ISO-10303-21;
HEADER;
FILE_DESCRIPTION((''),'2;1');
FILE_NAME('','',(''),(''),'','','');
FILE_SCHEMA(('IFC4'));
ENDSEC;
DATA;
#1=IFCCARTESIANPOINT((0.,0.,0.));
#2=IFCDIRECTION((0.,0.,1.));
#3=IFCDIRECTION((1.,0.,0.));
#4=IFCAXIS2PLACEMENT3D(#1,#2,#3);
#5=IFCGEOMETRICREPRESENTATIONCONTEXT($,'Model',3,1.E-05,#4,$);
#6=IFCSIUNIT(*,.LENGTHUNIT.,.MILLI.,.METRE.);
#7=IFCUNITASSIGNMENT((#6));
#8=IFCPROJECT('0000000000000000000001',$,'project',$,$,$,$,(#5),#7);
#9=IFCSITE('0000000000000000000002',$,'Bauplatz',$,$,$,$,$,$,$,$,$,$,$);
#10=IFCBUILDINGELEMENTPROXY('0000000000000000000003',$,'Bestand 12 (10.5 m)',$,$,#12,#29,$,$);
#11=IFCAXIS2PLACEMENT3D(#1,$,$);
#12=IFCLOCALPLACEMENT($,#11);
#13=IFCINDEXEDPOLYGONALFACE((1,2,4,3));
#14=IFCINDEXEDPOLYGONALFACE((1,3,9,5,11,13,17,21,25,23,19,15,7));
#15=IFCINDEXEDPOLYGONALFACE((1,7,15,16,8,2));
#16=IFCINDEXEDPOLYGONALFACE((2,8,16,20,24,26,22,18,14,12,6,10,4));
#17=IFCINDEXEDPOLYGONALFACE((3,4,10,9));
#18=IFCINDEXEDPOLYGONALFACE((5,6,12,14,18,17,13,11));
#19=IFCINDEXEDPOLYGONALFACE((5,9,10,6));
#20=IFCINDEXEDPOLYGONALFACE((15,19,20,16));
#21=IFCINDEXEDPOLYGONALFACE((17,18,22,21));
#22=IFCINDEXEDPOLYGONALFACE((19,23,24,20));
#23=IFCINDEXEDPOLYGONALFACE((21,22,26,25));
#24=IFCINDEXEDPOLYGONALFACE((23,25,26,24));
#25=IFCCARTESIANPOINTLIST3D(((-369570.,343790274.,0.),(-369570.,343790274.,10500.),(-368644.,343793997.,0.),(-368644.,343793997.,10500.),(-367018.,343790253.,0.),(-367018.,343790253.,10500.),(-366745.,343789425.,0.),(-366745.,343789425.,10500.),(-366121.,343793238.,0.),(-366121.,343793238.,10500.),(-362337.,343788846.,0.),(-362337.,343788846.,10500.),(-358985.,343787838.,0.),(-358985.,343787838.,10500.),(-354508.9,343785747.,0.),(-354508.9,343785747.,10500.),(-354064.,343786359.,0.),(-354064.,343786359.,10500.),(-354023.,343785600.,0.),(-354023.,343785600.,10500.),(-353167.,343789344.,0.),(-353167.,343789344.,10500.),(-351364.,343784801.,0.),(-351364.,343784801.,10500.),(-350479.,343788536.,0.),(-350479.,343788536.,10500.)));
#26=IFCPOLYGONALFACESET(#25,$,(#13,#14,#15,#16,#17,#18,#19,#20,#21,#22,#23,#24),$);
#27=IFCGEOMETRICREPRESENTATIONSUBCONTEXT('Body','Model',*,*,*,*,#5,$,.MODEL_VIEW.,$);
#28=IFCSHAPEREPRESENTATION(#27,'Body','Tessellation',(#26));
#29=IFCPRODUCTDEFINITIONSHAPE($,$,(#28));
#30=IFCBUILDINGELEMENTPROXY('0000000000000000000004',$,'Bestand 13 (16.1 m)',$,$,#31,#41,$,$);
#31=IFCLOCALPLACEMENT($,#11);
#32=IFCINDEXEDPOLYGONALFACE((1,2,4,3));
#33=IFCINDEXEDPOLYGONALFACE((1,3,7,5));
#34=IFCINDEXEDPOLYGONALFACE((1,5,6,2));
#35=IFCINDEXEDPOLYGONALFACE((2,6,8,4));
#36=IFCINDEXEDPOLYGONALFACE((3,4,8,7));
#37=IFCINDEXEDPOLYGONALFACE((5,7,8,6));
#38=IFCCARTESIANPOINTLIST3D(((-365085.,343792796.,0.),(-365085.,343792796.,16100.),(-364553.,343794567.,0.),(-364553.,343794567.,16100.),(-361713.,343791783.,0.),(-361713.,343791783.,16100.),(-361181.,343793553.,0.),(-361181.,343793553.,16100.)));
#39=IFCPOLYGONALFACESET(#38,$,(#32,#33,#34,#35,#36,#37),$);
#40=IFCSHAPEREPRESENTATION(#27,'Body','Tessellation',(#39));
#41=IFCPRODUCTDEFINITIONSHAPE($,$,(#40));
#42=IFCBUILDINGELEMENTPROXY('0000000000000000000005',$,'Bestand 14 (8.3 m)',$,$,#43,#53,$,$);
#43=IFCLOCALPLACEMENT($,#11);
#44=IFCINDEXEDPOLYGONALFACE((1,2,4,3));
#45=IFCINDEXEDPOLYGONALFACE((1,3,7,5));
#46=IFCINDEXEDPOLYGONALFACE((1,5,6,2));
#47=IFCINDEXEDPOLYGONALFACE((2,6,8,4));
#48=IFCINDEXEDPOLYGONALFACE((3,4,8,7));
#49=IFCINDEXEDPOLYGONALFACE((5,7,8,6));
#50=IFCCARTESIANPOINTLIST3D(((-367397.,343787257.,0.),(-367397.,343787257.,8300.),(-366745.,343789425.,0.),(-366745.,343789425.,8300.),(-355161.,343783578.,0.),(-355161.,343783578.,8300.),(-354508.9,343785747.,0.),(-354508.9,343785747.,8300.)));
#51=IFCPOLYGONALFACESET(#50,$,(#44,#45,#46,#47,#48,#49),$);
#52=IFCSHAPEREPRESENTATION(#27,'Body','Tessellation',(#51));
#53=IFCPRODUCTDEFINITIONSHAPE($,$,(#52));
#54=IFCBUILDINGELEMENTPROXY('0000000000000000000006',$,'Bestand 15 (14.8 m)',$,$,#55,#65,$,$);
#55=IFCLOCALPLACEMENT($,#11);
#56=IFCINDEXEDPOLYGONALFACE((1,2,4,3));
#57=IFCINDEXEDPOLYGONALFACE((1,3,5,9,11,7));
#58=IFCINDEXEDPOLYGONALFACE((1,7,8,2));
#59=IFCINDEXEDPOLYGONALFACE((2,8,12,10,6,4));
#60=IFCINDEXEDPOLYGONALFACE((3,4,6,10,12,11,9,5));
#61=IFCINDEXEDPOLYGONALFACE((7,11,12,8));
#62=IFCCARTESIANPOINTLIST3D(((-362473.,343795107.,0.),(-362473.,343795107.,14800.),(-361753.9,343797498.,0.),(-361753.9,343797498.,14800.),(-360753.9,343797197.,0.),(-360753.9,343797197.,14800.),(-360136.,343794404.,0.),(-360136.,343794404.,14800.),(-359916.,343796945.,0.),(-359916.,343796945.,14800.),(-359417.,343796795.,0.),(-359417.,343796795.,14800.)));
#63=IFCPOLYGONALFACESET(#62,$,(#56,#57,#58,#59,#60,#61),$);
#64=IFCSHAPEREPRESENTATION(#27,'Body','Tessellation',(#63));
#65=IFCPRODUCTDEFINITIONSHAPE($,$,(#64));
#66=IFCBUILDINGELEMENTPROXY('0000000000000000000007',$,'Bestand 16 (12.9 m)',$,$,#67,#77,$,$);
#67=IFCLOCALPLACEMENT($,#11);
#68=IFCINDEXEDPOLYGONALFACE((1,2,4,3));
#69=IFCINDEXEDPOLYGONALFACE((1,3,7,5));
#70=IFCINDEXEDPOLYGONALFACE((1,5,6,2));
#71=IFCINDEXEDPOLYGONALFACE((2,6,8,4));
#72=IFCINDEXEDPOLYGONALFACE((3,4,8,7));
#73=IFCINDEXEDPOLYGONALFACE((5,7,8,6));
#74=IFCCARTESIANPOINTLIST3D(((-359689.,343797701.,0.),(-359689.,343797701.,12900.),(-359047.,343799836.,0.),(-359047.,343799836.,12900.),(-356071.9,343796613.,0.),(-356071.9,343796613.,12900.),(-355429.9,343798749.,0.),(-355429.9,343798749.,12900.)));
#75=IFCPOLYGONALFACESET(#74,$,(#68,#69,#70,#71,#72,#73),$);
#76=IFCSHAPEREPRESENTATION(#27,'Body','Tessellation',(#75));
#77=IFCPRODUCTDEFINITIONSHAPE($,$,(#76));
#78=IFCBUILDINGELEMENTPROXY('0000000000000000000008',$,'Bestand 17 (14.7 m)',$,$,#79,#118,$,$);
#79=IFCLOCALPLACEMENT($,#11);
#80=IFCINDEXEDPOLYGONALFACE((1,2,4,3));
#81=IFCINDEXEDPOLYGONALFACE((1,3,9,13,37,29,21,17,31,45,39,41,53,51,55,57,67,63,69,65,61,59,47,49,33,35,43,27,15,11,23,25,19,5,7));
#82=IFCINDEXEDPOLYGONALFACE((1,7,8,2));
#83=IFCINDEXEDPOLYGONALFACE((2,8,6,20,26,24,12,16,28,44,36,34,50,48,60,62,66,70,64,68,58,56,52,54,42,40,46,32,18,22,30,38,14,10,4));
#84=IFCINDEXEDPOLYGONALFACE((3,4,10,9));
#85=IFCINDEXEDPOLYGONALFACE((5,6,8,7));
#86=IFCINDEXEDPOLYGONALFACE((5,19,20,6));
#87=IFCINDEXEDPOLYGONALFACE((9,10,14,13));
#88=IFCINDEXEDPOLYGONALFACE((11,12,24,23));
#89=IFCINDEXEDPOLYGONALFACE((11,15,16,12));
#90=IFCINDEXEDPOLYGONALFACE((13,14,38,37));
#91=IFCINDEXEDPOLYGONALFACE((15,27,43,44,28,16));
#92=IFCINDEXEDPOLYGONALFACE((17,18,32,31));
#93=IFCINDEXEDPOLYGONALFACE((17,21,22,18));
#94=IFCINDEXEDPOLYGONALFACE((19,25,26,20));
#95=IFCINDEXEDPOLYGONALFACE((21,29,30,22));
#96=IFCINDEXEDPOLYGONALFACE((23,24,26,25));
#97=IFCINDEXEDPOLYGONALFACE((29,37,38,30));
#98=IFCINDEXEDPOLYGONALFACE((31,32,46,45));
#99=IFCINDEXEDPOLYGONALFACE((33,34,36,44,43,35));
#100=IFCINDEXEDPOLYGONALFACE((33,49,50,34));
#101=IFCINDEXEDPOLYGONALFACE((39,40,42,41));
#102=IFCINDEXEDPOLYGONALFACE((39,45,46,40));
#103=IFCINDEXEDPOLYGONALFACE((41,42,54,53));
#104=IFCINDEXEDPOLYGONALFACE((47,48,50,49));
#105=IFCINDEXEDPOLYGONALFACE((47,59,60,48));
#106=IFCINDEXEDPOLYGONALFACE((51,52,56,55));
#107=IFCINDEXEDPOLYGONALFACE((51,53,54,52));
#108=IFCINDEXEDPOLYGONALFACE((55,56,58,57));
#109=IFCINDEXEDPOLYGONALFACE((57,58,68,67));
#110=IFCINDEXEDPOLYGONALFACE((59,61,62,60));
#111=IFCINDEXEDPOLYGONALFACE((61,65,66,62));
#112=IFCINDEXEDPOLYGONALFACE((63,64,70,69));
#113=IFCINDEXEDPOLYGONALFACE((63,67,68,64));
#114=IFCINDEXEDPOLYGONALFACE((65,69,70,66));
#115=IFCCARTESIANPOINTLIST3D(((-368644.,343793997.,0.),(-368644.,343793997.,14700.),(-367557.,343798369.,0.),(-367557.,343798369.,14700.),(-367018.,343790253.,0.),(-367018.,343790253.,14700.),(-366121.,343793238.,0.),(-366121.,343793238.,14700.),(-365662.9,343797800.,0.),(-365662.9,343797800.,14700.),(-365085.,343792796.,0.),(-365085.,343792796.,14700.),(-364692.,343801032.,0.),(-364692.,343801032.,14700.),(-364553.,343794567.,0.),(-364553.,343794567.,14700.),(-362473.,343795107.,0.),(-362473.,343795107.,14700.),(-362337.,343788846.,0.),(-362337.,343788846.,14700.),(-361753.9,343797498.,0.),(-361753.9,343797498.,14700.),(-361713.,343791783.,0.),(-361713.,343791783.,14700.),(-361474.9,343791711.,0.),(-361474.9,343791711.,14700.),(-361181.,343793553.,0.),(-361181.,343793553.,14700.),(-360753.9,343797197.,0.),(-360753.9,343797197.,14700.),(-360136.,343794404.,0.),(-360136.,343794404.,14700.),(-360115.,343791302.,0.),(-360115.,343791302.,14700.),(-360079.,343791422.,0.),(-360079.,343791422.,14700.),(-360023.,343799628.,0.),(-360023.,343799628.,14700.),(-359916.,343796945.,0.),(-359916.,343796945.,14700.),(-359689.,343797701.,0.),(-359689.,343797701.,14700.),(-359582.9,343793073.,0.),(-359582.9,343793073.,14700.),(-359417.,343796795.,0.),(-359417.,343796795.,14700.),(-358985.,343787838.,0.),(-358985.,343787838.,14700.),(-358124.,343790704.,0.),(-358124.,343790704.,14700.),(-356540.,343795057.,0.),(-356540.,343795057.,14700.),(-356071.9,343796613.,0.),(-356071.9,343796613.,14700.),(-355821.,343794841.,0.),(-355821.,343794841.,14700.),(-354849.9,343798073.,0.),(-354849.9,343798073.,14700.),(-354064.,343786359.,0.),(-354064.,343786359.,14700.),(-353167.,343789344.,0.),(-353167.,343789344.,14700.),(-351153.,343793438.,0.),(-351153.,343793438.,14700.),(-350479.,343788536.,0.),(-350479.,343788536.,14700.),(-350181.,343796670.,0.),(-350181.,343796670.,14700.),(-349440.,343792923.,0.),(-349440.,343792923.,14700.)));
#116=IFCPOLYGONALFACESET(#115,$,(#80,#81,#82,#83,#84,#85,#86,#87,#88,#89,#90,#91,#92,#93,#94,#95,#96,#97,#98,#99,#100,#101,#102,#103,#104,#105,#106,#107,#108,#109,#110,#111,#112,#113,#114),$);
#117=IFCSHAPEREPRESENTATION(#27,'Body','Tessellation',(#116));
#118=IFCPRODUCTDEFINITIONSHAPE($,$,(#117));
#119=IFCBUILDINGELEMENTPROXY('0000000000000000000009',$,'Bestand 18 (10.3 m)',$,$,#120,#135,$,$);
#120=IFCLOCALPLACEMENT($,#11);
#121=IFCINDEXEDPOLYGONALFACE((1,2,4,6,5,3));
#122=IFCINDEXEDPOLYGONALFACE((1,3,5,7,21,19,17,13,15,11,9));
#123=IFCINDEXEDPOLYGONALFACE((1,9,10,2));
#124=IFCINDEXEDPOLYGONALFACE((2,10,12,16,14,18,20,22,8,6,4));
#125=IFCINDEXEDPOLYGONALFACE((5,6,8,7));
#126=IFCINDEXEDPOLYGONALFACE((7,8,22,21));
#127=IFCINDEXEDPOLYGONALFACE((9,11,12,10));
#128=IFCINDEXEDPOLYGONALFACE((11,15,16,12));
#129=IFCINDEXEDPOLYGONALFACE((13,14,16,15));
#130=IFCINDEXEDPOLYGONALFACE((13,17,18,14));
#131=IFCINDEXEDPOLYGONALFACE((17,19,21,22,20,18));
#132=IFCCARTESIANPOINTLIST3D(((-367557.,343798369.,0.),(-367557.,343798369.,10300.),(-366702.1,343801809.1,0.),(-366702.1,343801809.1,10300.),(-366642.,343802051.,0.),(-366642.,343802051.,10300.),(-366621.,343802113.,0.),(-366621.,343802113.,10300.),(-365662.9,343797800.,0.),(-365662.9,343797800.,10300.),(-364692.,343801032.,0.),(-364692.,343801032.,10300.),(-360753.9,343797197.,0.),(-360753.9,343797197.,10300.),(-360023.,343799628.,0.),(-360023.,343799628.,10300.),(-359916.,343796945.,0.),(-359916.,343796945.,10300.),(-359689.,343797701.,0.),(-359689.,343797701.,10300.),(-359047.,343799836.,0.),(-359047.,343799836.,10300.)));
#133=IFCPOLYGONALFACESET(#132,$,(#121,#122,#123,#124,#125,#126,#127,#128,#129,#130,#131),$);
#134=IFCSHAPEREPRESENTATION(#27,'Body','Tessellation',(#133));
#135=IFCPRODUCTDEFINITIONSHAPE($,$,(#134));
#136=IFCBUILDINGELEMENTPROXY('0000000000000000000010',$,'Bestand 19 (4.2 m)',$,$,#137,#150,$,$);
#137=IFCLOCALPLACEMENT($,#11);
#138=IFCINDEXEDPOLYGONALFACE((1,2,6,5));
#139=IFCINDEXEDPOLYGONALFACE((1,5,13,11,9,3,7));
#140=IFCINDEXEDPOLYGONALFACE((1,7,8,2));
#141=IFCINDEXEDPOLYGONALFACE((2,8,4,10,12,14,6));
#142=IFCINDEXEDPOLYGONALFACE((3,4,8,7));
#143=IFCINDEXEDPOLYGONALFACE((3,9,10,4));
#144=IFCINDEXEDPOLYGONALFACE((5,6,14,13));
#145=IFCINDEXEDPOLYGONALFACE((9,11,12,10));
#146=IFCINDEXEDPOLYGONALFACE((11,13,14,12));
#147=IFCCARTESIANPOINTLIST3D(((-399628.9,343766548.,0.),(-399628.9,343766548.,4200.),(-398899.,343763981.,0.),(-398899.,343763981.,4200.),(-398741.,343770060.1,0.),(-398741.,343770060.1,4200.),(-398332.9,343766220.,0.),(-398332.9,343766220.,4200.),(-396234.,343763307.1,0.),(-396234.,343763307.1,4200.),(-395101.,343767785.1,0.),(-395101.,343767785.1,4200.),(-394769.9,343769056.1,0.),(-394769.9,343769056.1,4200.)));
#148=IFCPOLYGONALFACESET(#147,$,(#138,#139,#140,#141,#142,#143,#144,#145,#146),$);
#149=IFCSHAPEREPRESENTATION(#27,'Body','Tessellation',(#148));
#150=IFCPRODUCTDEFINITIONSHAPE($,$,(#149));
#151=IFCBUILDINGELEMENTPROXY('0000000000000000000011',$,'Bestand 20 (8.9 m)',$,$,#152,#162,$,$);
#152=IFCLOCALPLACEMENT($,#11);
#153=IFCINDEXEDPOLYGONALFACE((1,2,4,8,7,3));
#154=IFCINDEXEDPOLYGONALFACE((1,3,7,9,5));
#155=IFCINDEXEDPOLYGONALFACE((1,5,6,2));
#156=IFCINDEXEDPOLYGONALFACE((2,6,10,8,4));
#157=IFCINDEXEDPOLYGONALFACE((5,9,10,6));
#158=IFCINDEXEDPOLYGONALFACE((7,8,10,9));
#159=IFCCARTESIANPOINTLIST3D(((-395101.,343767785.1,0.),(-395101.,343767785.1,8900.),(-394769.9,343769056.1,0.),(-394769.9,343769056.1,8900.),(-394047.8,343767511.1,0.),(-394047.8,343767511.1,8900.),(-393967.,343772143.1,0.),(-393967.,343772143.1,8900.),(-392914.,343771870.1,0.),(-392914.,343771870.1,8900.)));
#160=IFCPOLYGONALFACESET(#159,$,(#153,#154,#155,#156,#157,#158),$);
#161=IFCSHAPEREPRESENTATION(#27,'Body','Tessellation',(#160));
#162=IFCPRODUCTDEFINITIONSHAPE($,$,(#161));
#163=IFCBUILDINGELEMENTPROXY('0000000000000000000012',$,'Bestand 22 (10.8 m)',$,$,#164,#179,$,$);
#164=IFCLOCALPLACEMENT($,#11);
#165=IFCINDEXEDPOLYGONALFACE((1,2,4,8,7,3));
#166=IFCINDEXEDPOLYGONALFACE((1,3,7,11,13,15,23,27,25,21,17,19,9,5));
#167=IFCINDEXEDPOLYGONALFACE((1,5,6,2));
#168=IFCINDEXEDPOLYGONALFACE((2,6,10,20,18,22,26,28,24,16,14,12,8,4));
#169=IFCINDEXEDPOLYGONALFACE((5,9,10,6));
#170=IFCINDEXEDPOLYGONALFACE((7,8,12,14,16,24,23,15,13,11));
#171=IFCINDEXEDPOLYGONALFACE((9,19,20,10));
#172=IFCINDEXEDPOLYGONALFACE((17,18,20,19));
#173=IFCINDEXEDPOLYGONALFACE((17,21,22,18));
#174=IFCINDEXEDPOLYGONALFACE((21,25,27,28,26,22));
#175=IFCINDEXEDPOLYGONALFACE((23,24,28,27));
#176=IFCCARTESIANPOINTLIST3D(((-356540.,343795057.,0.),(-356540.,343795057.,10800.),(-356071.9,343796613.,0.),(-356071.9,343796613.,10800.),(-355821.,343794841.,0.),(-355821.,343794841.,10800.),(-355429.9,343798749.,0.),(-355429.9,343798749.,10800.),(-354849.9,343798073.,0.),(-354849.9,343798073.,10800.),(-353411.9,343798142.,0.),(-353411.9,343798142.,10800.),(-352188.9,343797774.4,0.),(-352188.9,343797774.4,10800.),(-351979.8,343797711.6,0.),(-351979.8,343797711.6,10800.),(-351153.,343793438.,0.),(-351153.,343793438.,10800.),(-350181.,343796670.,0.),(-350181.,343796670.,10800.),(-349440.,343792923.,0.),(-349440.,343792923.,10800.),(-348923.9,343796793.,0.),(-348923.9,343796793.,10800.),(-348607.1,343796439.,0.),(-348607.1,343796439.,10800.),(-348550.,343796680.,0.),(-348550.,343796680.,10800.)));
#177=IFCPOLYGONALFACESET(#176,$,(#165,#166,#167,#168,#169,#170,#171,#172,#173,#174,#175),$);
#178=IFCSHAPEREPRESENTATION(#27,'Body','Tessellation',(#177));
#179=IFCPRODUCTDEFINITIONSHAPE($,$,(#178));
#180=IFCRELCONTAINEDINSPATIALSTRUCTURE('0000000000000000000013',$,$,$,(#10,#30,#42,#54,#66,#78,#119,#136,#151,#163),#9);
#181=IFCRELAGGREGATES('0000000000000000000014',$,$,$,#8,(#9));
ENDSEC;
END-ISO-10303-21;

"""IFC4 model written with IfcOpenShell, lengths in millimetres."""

from ifc_helpers import new_model, si_unit, origin_with_axes, place, context, subcontext, project, spatial, indexed_curve, outline, extrude, element, save


model = new_model("IFC4")

# Units and contexts
model_context = context("Model", 3, precision=1e-05, world=origin_with_axes())
body_context = subcontext(model_context, "Body", "Model", "MODEL_VIEW")
ifc_project = project(units=[si_unit("LENGTHUNIT", "METRE", prefix="MILLI")], contexts=[model_context])

# Site
site = spatial("IfcSite", under=ifc_project, Name="Bauplatz")

# Building element proxies
proxy_1_placement = place(None, origin_with_axes())
element("IfcBuildingElementProxy", 1, at=proxy_1_placement, inside=site, Name="Bestand 12 (10.5 m)", context=body_context, shape_type="SweptSolid", body=[
    extrude(outline(indexed_curve([(-366121.0, 343793238.0), (-368644.0, 343793997.0), (-369570.0, 343790274.0), (-366745.0, 343789425.0), (-354508.9, 343785747.0), (-354023.0, 343785600.0), (-351364.0, 343784801.0), (-350479.0, 343788536.0), (-353167.0, 343789344.0), (-354064.0, 343786359.0), (-358985.0, 343787838.0), (-362337.0, 343788846.0), (-367018.0, 343790253.0)])), None, (0.0, 0.0, 1.0), 10500.0),
])
proxy_2_placement = place(None, origin_with_axes())
element("IfcBuildingElementProxy", 2, at=proxy_2_placement, inside=site, Name="Bestand 13 (16.1 m)", context=body_context, shape_type="SweptSolid", body=[
    extrude(outline(indexed_curve([(-361181.0, 343793553.0), (-364553.0, 343794567.0), (-365085.0, 343792796.0), (-361713.0, 343791783.0)])), None, (0.0, 0.0, 1.0), 16100.0),
])
proxy_3_placement = place(None, origin_with_axes())
element("IfcBuildingElementProxy", 3, at=proxy_3_placement, inside=site, Name="Bestand 14 (8.3 m)", context=body_context, shape_type="SweptSolid", body=[
    extrude(outline(indexed_curve([(-354508.9, 343785747.0), (-366745.0, 343789425.0), (-367397.0, 343787257.0), (-355161.0, 343783578.0)])), None, (0.0, 0.0, 1.0), 8300.0),
])
proxy_4_placement = place(None, origin_with_axes())
element("IfcBuildingElementProxy", 4, at=proxy_4_placement, inside=site, Name="Bestand 15 (14.8 m)", context=body_context, shape_type="SweptSolid", body=[
    extrude(outline(indexed_curve([(-360753.9, 343797197.0), (-361753.9, 343797498.0), (-362473.0, 343795107.0), (-360136.0, 343794404.0), (-359417.0, 343796795.0), (-359916.0, 343796945.0)])), None, (0.0, 0.0, 1.0), 14800.0),
])
proxy_5_placement = place(None, origin_with_axes())
element("IfcBuildingElementProxy", 5, at=proxy_5_placement, inside=site, Name="Bestand 16 (12.9 m)", context=body_context, shape_type="SweptSolid", body=[
    extrude(outline(indexed_curve([(-355429.9, 343798749.0), (-359047.0, 343799836.0), (-359689.0, 343797701.0), (-356071.9, 343796613.0)])), None, (0.0, 0.0, 1.0), 12900.0),
])
proxy_6_placement = place(None, origin_with_axes())
element("IfcBuildingElementProxy", 6, at=proxy_6_placement, inside=site, Name="Bestand 17 (14.7 m)", context=body_context, shape_type="SweptSolid", body=[
    extrude(outline(indexed_curve([(-360023.0, 343799628.0), (-364692.0, 343801032.0), (-365662.9, 343797800.0), (-367557.0, 343798369.0), (-368644.0, 343793997.0), (-366121.0, 343793238.0), (-367018.0, 343790253.0), (-362337.0, 343788846.0), (-361474.9, 343791711.0), (-361713.0, 343791783.0), (-365085.0, 343792796.0), (-364553.0, 343794567.0), (-361181.0, 343793553.0), (-359582.9, 343793073.0), (-360079.0, 343791422.0), (-360115.0, 343791302.0), (-358124.0, 343790704.0), (-358985.0, 343787838.0), (-354064.0, 343786359.0), (-353167.0, 343789344.0), (-350479.0, 343788536.0), (-349440.0, 343792923.0), (-351153.0, 343793438.0), (-350181.0, 343796670.0), (-354849.9, 343798073.0), (-355821.0, 343794841.0), (-356540.0, 343795057.0), (-356071.9, 343796613.0), (-359689.0, 343797701.0), (-359916.0, 343796945.0), (-359417.0, 343796795.0), (-360136.0, 343794404.0), (-362473.0, 343795107.0), (-361753.9, 343797498.0), (-360753.9, 343797197.0)])), None, (0.0, 0.0, 1.0), 14700.0),
])
proxy_7_placement = place(None, origin_with_axes())
element("IfcBuildingElementProxy", 7, at=proxy_7_placement, inside=site, Name="Bestand 18 (10.3 m)", context=body_context, shape_type="SweptSolid", body=[
    extrude(outline(indexed_curve([(-359047.0, 343799836.0), (-366621.0, 343802113.0), (-366642.0, 343802051.0), (-366702.1, 343801809.1), (-367557.0, 343798369.0), (-365662.9, 343797800.0), (-364692.0, 343801032.0), (-360023.0, 343799628.0), (-360753.9, 343797197.0), (-359916.0, 343796945.0), (-359689.0, 343797701.0)])), None, (0.0, 0.0, 1.0), 10300.0),
])
proxy_8_placement = place(None, origin_with_axes())
element("IfcBuildingElementProxy", 8, at=proxy_8_placement, inside=site, Name="Bestand 19 (4.2 m)", context=body_context, shape_type="SweptSolid", body=[
    extrude(outline(indexed_curve([(-394769.9, 343769056.1), (-398741.0, 343770060.1), (-399628.9, 343766548.0), (-398332.9, 343766220.0), (-398899.0, 343763981.0), (-396234.0, 343763307.1), (-395101.0, 343767785.1)])), None, (0.0, 0.0, 1.0), 4200.0),
])
proxy_9_placement = place(None, origin_with_axes())
element("IfcBuildingElementProxy", 9, at=proxy_9_placement, inside=site, Name="Bestand 20 (8.9 m)", context=body_context, shape_type="SweptSolid", body=[
    extrude(outline(indexed_curve([(-392914.0, 343771870.1), (-393967.0, 343772143.1), (-394769.9, 343769056.1), (-395101.0, 343767785.1), (-394047.8, 343767511.1)])), None, (0.0, 0.0, 1.0), 8900.0),
])
proxy_10_placement = place(None, origin_with_axes())
element("IfcBuildingElementProxy", 10, at=proxy_10_placement, inside=site, Name="Bestand 22 (10.8 m)", context=body_context, shape_type="SweptSolid", body=[
    extrude(outline(indexed_curve([(-353411.9, 343798142.0), (-355429.9, 343798749.0), (-356071.9, 343796613.0), (-356540.0, 343795057.0), (-355821.0, 343794841.0), (-354849.9, 343798073.0), (-350181.0, 343796670.0), (-351153.0, 343793438.0), (-349440.0, 343792923.0), (-348607.1, 343796439.0), (-348550.0, 343796680.0), (-348923.9, 343796793.0), (-351979.8, 343797711.6), (-352188.9, 343797774.4)])), None, (0.0, 0.0, 1.0), 10800.0),
])

save(model, "model.ifc")
